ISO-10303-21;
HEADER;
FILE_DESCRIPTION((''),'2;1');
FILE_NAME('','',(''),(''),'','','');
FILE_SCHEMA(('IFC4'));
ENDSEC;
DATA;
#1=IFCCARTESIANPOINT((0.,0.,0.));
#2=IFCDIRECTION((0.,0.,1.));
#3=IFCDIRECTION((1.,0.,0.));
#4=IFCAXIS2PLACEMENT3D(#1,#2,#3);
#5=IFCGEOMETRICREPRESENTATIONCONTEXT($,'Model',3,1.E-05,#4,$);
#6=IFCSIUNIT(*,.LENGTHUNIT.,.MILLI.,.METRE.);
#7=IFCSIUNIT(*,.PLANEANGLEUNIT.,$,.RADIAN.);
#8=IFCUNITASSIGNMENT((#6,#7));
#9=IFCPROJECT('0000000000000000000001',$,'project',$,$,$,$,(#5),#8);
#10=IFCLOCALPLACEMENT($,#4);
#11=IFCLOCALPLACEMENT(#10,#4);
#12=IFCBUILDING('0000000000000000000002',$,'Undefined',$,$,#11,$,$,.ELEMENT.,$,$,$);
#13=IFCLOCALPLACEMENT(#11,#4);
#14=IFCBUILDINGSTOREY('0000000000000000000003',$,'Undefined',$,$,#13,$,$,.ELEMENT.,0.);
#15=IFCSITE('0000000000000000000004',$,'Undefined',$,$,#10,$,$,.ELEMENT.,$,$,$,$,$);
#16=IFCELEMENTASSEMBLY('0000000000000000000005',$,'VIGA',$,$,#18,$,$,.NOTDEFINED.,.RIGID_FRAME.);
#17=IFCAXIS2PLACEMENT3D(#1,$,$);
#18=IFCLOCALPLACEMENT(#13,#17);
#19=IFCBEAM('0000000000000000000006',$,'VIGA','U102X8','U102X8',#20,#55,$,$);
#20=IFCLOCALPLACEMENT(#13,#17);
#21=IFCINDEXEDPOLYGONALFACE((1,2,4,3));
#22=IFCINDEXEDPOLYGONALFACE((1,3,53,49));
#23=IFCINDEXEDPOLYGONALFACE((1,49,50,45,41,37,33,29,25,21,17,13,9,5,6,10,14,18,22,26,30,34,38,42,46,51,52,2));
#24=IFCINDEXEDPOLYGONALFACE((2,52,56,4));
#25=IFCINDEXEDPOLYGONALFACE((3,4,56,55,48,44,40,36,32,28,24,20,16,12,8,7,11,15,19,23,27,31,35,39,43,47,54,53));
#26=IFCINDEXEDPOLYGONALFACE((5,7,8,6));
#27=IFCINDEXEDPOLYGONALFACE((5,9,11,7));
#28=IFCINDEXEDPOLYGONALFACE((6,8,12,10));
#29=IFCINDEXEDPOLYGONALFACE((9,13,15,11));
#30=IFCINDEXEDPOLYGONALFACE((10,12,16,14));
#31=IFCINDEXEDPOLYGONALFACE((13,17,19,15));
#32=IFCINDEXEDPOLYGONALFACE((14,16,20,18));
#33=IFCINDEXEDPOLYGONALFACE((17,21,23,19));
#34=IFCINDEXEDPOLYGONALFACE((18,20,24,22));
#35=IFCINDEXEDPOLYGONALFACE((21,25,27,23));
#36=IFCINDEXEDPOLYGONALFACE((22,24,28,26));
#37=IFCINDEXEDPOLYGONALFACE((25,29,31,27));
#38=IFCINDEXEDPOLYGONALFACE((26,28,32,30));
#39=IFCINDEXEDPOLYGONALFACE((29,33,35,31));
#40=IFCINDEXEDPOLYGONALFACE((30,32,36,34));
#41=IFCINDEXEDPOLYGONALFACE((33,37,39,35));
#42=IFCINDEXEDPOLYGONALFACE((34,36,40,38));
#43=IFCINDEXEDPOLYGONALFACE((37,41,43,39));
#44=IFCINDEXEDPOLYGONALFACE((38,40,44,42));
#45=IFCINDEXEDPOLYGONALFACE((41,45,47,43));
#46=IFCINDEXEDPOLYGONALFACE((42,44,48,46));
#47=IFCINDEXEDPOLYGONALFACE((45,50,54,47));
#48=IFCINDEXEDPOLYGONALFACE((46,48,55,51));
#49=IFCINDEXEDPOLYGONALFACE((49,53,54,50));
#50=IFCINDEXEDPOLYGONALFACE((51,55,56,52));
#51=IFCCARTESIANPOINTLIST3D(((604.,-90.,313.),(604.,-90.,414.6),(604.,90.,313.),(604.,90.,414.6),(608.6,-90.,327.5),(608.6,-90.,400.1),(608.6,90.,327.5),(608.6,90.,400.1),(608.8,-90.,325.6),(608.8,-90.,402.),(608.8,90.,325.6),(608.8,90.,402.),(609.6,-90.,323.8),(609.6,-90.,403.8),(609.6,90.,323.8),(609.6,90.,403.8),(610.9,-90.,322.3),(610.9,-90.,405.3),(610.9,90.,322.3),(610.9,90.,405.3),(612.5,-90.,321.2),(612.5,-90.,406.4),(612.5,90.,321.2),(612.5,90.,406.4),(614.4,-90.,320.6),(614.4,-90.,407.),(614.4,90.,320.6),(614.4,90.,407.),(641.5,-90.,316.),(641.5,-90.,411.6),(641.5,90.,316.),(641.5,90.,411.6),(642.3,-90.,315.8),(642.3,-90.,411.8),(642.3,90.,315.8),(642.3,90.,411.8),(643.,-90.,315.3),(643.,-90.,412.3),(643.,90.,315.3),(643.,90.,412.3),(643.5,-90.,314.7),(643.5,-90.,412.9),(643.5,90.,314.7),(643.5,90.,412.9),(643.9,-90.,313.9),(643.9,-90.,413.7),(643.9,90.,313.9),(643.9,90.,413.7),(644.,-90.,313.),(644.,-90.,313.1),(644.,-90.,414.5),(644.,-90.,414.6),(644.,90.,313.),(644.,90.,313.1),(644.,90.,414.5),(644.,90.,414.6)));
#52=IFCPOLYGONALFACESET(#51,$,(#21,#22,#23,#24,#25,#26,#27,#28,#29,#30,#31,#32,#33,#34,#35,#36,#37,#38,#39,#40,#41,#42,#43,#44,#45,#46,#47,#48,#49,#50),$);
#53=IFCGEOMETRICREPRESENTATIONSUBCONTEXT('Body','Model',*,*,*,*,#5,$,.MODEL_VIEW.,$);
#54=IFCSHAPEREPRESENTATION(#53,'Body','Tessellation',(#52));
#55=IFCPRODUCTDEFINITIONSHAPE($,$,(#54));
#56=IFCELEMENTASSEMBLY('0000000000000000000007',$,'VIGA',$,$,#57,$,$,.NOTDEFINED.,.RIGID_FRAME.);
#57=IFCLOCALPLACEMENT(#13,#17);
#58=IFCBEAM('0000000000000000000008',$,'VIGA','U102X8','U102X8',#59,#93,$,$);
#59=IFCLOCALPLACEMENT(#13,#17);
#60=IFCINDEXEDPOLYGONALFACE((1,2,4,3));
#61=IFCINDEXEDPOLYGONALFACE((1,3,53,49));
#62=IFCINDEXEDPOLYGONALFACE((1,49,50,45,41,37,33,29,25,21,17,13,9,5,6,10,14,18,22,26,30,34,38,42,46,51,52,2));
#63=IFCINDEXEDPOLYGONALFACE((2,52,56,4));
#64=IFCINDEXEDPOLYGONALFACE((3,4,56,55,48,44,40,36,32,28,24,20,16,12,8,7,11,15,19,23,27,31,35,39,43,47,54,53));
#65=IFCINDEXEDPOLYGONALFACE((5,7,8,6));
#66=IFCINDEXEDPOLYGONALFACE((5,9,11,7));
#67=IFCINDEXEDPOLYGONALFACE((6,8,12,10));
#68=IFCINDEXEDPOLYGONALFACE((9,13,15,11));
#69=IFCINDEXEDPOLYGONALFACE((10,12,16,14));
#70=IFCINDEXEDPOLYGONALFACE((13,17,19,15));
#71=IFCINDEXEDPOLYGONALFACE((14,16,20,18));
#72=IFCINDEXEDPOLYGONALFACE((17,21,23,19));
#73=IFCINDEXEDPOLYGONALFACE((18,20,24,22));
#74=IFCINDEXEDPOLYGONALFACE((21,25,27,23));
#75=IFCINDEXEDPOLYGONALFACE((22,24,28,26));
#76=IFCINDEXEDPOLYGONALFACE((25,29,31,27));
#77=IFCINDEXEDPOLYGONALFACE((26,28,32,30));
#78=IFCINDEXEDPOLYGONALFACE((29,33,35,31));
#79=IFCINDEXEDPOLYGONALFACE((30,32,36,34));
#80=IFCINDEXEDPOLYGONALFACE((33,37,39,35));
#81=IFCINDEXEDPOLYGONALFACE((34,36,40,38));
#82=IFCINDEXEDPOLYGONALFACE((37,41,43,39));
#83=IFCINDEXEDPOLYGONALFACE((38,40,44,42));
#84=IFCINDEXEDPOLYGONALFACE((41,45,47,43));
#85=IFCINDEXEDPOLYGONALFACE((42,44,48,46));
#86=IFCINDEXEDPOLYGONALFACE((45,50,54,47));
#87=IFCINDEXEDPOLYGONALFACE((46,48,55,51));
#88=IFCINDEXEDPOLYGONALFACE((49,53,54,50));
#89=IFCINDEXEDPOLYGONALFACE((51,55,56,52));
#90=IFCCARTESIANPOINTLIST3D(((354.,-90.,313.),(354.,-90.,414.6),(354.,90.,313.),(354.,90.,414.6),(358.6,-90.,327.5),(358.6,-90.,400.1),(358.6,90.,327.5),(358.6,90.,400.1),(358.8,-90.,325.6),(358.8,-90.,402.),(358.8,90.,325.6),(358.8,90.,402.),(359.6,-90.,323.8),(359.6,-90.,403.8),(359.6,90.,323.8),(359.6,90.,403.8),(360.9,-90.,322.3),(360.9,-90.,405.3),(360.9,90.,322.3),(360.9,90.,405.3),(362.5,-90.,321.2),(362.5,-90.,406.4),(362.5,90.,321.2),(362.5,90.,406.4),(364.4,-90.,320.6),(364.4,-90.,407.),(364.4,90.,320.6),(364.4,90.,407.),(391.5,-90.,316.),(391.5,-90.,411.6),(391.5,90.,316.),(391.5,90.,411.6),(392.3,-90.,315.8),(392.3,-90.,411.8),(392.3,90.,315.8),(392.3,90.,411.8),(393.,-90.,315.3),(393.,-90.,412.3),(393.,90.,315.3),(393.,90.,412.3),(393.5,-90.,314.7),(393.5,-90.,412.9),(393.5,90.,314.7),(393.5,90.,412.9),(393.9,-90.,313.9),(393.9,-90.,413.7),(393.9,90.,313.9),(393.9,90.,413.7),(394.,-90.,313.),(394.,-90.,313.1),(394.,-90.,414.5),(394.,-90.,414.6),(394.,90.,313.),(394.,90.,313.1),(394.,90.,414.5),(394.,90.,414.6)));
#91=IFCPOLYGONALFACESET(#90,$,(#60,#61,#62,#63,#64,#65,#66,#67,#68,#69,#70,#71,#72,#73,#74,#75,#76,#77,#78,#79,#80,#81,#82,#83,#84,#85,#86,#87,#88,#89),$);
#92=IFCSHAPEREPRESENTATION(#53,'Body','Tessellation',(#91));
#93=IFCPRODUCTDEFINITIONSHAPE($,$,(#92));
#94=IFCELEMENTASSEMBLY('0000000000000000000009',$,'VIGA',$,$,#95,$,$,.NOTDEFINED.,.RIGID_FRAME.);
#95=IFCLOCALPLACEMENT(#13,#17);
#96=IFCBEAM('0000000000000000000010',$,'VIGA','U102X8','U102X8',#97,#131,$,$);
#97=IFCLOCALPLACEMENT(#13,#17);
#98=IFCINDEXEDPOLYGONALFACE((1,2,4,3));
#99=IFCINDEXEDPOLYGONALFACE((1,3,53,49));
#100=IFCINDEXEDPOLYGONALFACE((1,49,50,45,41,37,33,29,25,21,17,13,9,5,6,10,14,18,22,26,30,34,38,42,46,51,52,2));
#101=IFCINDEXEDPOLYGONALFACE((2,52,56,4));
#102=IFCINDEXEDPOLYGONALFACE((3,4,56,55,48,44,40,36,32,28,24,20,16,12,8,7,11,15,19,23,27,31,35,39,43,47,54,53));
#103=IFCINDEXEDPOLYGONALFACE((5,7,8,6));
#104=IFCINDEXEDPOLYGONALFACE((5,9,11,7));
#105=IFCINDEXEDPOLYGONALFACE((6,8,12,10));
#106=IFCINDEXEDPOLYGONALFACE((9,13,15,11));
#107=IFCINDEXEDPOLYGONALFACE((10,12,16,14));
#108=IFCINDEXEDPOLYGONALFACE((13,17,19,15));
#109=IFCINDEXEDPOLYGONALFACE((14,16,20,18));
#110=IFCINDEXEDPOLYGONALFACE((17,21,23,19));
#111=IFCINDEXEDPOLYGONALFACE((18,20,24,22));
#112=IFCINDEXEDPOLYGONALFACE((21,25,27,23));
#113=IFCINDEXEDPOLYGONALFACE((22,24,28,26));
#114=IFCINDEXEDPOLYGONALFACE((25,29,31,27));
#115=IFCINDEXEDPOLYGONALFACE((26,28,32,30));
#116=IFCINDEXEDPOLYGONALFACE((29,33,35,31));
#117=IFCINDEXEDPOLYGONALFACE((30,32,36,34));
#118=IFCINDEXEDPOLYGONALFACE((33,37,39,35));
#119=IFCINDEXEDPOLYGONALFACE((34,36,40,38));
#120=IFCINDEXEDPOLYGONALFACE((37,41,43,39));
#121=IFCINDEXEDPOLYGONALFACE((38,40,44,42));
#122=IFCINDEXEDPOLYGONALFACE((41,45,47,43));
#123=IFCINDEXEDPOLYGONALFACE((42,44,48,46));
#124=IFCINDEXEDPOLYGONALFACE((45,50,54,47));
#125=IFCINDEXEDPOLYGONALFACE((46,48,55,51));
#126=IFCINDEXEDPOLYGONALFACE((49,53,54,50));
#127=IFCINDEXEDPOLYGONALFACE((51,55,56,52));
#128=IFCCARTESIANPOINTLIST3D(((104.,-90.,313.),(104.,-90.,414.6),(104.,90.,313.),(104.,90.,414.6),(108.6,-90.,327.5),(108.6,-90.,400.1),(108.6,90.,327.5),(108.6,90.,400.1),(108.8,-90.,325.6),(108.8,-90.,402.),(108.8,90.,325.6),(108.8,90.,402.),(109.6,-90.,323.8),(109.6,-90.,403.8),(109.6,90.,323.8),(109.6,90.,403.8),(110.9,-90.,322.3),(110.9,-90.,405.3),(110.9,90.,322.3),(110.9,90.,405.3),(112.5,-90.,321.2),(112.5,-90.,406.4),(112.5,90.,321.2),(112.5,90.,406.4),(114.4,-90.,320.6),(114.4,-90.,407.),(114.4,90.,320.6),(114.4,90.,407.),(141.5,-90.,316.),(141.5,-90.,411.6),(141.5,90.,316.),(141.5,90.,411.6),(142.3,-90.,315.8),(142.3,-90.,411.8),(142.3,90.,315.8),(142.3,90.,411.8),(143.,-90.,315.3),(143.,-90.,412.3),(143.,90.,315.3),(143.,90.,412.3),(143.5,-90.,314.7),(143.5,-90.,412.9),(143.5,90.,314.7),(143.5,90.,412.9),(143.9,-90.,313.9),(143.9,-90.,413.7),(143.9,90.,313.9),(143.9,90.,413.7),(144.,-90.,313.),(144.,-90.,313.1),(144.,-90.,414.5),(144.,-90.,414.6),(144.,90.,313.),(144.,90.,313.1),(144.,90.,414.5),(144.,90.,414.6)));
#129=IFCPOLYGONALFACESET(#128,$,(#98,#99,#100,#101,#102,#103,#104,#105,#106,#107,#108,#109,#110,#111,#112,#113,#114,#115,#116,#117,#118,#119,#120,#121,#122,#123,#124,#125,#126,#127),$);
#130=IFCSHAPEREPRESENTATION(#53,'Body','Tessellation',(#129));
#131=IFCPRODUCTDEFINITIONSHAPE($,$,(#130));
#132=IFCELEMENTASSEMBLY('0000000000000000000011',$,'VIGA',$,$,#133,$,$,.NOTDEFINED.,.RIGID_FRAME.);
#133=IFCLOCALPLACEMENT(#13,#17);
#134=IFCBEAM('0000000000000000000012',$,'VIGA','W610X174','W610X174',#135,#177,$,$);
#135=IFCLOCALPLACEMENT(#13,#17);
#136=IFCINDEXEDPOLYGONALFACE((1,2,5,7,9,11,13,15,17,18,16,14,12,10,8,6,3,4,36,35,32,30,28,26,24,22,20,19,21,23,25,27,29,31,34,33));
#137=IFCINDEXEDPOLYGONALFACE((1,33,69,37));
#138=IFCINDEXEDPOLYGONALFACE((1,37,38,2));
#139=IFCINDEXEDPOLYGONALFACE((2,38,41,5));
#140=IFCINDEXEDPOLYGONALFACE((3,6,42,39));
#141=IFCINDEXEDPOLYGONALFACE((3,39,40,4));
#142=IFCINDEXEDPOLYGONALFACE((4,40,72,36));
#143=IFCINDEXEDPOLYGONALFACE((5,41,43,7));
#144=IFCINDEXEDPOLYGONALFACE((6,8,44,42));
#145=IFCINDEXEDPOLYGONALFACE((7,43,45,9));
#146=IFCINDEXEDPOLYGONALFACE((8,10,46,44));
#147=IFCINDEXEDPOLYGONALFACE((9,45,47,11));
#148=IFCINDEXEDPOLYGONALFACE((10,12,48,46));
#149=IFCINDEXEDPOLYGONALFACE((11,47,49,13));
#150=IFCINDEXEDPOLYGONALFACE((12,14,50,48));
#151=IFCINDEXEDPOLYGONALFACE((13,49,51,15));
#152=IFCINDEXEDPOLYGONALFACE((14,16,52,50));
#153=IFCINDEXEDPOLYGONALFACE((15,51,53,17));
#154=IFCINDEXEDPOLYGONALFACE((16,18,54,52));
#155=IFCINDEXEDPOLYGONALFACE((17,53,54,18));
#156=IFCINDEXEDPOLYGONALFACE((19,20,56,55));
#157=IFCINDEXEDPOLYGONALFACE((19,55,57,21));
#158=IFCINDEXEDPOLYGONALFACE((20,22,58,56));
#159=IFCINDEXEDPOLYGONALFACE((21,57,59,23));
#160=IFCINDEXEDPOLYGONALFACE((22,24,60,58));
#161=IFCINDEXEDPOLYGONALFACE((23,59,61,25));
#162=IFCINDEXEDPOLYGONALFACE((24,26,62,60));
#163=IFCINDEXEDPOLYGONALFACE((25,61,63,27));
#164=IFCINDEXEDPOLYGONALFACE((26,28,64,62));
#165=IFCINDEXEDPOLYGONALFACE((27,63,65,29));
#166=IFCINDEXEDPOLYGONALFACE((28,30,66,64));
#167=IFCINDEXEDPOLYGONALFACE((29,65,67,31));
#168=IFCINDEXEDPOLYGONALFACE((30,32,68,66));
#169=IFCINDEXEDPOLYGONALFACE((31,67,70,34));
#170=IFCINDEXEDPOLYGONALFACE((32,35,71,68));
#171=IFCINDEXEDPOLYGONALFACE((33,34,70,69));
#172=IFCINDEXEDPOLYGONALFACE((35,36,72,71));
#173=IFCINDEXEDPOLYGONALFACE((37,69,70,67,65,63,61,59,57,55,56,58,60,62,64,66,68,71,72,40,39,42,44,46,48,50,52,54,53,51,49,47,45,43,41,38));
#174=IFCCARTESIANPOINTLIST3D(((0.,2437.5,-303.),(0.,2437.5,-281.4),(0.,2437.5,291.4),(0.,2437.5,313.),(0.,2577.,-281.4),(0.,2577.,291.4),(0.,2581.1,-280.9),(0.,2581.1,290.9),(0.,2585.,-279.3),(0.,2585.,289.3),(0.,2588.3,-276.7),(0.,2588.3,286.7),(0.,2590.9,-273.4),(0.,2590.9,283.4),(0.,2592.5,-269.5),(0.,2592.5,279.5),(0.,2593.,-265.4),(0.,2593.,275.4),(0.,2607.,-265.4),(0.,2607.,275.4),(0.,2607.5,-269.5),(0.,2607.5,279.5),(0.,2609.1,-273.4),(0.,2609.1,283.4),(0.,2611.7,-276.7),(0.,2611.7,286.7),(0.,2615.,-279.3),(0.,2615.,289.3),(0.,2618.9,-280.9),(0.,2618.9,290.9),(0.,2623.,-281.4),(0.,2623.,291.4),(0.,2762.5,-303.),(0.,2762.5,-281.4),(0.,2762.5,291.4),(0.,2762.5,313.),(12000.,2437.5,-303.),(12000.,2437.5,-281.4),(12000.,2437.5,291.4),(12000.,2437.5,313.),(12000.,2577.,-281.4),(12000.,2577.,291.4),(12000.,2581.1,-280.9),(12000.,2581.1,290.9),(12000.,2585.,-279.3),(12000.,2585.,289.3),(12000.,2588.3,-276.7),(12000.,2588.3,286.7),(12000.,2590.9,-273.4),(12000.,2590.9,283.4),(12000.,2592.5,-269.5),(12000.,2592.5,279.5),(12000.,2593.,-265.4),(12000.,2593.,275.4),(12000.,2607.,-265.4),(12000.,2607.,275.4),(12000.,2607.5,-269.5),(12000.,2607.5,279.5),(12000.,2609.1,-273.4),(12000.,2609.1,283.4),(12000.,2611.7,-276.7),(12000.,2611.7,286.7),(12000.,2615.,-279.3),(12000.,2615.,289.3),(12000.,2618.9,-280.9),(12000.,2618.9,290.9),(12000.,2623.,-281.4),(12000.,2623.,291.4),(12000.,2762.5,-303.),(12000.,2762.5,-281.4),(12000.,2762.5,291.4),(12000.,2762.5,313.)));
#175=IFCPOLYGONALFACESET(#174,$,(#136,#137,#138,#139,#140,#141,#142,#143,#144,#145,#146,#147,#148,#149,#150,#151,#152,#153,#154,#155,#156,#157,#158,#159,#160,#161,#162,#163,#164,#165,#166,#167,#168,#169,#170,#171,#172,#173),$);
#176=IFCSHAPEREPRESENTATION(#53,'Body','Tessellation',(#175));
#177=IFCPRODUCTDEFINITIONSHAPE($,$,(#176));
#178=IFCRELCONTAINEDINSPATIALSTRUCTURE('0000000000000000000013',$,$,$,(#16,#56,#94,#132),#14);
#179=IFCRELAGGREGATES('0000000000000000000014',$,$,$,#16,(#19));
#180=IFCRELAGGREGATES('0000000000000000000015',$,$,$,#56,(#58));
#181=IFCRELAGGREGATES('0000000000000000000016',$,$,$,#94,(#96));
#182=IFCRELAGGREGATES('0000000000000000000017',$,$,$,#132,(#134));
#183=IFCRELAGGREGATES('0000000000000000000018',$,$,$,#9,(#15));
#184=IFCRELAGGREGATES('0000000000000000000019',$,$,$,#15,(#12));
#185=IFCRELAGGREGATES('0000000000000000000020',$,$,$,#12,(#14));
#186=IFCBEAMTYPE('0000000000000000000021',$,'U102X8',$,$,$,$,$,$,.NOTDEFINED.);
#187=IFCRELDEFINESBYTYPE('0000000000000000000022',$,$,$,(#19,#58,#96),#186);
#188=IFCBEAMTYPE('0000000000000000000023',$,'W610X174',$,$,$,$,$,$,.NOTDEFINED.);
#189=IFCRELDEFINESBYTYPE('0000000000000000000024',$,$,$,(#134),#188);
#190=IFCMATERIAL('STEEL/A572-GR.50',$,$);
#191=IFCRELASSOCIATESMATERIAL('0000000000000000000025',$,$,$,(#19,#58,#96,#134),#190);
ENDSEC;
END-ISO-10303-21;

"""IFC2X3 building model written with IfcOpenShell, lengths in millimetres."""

from ifc_helpers import new_model, si_unit, frame, origin_with_axes, origin_2d_with_axis, place, context, subcontext, project, spatial, i_section, u_section, extrude, material, type_object, element, aggregate, save


model = new_model("IFC2X3")

# Units and contexts
model_context = context("Model", 3, precision=1e-05, world=origin_with_axes())
body_context = subcontext(model_context, "Body", "Model", "MODEL_VIEW")
ifc_project = project(units=[si_unit("LENGTHUNIT", "METRE", prefix="MILLI"), si_unit("PLANEANGLEUNIT", "RADIAN")], contexts=[model_context])

# Site, building, storey
site_placement = place(None, origin_with_axes())
site = spatial("IfcSite", under=ifc_project, at=site_placement, Name="Undefined", CompositionType="ELEMENT")
building_placement = place(site_placement, origin_with_axes())
building = spatial("IfcBuilding", under=site, at=building_placement, Name="Undefined", CompositionType="ELEMENT")
storey_placement = place(building_placement, origin_with_axes())
storey = spatial("IfcBuildingStorey", under=building, at=storey_placement, Name="Undefined", CompositionType="ELEMENT", Elevation=0.0)

# Element assemblies, beams
ifc_material_1 = material(Name="STEEL/A572-GR.50")
beam_type_1 = type_object("IfcBeamType", Name="U102X8", PredefinedType="NOTDEFINED")
assembly_1_placement = place(storey_placement, origin_with_axes())
assembly_1 = element("IfcElementAssembly", 1, at=assembly_1_placement, inside=storey, Name="VIGA", AssemblyPlace="NOTDEFINED", PredefinedType="RIGID_FRAME")
beam_1_placement = place(assembly_1_placement, frame((624.0, -90.0, 363.8), z_axis=(0.0, 0.0, 1.0), x_axis=(0.0, 1.0, 0.0)))
beam_1 = element("IfcBeam", 2, at=beam_1_placement, type_object=beam_type_1, material=ifc_material_1, Name="VIGA", Description="U102X8", ObjectType="U102X8", context=body_context, shape_type="SweptSolid", body=[
    extrude(u_section(Depth=101.6, FlangeWidth=40.0, WebThickness=4.6, FlangeThickness=6.0, FilletRadius=7.0, EdgeRadius=3.0, FlangeSlope=0.16839, at=origin_2d_with_axis()), frame((180.0, 0.0, 0.0), z_axis=(-1.0, 0.0, 0.0), x_axis=(0.0, -1.0, 0.0)), (0.0, 0.0, 1.0), 180.0),
])
aggregate(assembly_1, [beam_1])
assembly_2_placement = place(storey_placement, origin_with_axes())
assembly_2 = element("IfcElementAssembly", 3, at=assembly_2_placement, inside=storey, Name="VIGA", AssemblyPlace="NOTDEFINED", PredefinedType="RIGID_FRAME")
beam_2_placement = place(assembly_2_placement, frame((374.0, -90.0, 363.8), z_axis=(0.0, 0.0, 1.0), x_axis=(0.0, 1.0, 0.0)))
beam_2 = element("IfcBeam", 4, at=beam_2_placement, type_object=beam_type_1, material=ifc_material_1, Name="VIGA", Description="U102X8", ObjectType="U102X8", context=body_context, shape_type="SweptSolid", body=[
    extrude(u_section(Depth=101.6, FlangeWidth=40.0, WebThickness=4.6, FlangeThickness=6.0, FilletRadius=7.0, EdgeRadius=3.0, FlangeSlope=0.16839, at=origin_2d_with_axis()), frame((180.0, 0.0, 0.0), z_axis=(-1.0, 0.0, 0.0), x_axis=(0.0, -1.0, 0.0)), (0.0, 0.0, 1.0), 180.0),
])
aggregate(assembly_2, [beam_2])
assembly_3_placement = place(storey_placement, origin_with_axes())
assembly_3 = element("IfcElementAssembly", 5, at=assembly_3_placement, inside=storey, Name="VIGA", AssemblyPlace="NOTDEFINED", PredefinedType="RIGID_FRAME")
beam_3_placement = place(assembly_3_placement, frame((124.0, -90.0, 363.8), z_axis=(0.0, 0.0, 1.0), x_axis=(0.0, 1.0, 0.0)))
beam_3 = element("IfcBeam", 6, at=beam_3_placement, type_object=beam_type_1, material=ifc_material_1, Name="VIGA", Description="U102X8", ObjectType="U102X8", context=body_context, shape_type="SweptSolid", body=[
    extrude(u_section(Depth=101.6, FlangeWidth=40.0, WebThickness=4.6, FlangeThickness=6.0, FilletRadius=7.0, EdgeRadius=3.0, FlangeSlope=0.16839, at=origin_2d_with_axis()), frame((180.0, 0.0, 0.0), z_axis=(-1.0, 0.0, 0.0), x_axis=(0.0, -1.0, 0.0)), (0.0, 0.0, 1.0), 180.0),
])
aggregate(assembly_3, [beam_3])
assembly_4_placement = place(storey_placement, origin_with_axes())
assembly_4 = element("IfcElementAssembly", 7, at=assembly_4_placement, inside=storey, Name="VIGA", AssemblyPlace="NOTDEFINED", PredefinedType="RIGID_FRAME")
beam_type_2 = type_object("IfcBeamType", Name="W610X174", PredefinedType="NOTDEFINED")
beam_4_placement = place(assembly_4_placement, frame((0.0, 2600.0, 5.0), z_axis=(0.0, 0.0, 1.0), x_axis=(1.0, 0.0, 0.0)))
beam_4 = element("IfcBeam", 8, at=beam_4_placement, type_object=beam_type_2, material=ifc_material_1, Name="VIGA", Description="W610X174", ObjectType="W610X174", context=body_context, shape_type="SweptSolid", body=[
    extrude(i_section(OverallWidth=325.0, OverallDepth=616.0, WebThickness=14.0, FlangeThickness=21.6, FilletRadius=16.0, at=origin_2d_with_axis()), frame((12000.0, 0.0, 0.0), z_axis=(-1.0, 0.0, 0.0), x_axis=(0.0, -1.0, 0.0)), (0.0, 0.0, 1.0), 12000.0),
])
aggregate(assembly_4, [beam_4])

save(model, "model.ifc")
